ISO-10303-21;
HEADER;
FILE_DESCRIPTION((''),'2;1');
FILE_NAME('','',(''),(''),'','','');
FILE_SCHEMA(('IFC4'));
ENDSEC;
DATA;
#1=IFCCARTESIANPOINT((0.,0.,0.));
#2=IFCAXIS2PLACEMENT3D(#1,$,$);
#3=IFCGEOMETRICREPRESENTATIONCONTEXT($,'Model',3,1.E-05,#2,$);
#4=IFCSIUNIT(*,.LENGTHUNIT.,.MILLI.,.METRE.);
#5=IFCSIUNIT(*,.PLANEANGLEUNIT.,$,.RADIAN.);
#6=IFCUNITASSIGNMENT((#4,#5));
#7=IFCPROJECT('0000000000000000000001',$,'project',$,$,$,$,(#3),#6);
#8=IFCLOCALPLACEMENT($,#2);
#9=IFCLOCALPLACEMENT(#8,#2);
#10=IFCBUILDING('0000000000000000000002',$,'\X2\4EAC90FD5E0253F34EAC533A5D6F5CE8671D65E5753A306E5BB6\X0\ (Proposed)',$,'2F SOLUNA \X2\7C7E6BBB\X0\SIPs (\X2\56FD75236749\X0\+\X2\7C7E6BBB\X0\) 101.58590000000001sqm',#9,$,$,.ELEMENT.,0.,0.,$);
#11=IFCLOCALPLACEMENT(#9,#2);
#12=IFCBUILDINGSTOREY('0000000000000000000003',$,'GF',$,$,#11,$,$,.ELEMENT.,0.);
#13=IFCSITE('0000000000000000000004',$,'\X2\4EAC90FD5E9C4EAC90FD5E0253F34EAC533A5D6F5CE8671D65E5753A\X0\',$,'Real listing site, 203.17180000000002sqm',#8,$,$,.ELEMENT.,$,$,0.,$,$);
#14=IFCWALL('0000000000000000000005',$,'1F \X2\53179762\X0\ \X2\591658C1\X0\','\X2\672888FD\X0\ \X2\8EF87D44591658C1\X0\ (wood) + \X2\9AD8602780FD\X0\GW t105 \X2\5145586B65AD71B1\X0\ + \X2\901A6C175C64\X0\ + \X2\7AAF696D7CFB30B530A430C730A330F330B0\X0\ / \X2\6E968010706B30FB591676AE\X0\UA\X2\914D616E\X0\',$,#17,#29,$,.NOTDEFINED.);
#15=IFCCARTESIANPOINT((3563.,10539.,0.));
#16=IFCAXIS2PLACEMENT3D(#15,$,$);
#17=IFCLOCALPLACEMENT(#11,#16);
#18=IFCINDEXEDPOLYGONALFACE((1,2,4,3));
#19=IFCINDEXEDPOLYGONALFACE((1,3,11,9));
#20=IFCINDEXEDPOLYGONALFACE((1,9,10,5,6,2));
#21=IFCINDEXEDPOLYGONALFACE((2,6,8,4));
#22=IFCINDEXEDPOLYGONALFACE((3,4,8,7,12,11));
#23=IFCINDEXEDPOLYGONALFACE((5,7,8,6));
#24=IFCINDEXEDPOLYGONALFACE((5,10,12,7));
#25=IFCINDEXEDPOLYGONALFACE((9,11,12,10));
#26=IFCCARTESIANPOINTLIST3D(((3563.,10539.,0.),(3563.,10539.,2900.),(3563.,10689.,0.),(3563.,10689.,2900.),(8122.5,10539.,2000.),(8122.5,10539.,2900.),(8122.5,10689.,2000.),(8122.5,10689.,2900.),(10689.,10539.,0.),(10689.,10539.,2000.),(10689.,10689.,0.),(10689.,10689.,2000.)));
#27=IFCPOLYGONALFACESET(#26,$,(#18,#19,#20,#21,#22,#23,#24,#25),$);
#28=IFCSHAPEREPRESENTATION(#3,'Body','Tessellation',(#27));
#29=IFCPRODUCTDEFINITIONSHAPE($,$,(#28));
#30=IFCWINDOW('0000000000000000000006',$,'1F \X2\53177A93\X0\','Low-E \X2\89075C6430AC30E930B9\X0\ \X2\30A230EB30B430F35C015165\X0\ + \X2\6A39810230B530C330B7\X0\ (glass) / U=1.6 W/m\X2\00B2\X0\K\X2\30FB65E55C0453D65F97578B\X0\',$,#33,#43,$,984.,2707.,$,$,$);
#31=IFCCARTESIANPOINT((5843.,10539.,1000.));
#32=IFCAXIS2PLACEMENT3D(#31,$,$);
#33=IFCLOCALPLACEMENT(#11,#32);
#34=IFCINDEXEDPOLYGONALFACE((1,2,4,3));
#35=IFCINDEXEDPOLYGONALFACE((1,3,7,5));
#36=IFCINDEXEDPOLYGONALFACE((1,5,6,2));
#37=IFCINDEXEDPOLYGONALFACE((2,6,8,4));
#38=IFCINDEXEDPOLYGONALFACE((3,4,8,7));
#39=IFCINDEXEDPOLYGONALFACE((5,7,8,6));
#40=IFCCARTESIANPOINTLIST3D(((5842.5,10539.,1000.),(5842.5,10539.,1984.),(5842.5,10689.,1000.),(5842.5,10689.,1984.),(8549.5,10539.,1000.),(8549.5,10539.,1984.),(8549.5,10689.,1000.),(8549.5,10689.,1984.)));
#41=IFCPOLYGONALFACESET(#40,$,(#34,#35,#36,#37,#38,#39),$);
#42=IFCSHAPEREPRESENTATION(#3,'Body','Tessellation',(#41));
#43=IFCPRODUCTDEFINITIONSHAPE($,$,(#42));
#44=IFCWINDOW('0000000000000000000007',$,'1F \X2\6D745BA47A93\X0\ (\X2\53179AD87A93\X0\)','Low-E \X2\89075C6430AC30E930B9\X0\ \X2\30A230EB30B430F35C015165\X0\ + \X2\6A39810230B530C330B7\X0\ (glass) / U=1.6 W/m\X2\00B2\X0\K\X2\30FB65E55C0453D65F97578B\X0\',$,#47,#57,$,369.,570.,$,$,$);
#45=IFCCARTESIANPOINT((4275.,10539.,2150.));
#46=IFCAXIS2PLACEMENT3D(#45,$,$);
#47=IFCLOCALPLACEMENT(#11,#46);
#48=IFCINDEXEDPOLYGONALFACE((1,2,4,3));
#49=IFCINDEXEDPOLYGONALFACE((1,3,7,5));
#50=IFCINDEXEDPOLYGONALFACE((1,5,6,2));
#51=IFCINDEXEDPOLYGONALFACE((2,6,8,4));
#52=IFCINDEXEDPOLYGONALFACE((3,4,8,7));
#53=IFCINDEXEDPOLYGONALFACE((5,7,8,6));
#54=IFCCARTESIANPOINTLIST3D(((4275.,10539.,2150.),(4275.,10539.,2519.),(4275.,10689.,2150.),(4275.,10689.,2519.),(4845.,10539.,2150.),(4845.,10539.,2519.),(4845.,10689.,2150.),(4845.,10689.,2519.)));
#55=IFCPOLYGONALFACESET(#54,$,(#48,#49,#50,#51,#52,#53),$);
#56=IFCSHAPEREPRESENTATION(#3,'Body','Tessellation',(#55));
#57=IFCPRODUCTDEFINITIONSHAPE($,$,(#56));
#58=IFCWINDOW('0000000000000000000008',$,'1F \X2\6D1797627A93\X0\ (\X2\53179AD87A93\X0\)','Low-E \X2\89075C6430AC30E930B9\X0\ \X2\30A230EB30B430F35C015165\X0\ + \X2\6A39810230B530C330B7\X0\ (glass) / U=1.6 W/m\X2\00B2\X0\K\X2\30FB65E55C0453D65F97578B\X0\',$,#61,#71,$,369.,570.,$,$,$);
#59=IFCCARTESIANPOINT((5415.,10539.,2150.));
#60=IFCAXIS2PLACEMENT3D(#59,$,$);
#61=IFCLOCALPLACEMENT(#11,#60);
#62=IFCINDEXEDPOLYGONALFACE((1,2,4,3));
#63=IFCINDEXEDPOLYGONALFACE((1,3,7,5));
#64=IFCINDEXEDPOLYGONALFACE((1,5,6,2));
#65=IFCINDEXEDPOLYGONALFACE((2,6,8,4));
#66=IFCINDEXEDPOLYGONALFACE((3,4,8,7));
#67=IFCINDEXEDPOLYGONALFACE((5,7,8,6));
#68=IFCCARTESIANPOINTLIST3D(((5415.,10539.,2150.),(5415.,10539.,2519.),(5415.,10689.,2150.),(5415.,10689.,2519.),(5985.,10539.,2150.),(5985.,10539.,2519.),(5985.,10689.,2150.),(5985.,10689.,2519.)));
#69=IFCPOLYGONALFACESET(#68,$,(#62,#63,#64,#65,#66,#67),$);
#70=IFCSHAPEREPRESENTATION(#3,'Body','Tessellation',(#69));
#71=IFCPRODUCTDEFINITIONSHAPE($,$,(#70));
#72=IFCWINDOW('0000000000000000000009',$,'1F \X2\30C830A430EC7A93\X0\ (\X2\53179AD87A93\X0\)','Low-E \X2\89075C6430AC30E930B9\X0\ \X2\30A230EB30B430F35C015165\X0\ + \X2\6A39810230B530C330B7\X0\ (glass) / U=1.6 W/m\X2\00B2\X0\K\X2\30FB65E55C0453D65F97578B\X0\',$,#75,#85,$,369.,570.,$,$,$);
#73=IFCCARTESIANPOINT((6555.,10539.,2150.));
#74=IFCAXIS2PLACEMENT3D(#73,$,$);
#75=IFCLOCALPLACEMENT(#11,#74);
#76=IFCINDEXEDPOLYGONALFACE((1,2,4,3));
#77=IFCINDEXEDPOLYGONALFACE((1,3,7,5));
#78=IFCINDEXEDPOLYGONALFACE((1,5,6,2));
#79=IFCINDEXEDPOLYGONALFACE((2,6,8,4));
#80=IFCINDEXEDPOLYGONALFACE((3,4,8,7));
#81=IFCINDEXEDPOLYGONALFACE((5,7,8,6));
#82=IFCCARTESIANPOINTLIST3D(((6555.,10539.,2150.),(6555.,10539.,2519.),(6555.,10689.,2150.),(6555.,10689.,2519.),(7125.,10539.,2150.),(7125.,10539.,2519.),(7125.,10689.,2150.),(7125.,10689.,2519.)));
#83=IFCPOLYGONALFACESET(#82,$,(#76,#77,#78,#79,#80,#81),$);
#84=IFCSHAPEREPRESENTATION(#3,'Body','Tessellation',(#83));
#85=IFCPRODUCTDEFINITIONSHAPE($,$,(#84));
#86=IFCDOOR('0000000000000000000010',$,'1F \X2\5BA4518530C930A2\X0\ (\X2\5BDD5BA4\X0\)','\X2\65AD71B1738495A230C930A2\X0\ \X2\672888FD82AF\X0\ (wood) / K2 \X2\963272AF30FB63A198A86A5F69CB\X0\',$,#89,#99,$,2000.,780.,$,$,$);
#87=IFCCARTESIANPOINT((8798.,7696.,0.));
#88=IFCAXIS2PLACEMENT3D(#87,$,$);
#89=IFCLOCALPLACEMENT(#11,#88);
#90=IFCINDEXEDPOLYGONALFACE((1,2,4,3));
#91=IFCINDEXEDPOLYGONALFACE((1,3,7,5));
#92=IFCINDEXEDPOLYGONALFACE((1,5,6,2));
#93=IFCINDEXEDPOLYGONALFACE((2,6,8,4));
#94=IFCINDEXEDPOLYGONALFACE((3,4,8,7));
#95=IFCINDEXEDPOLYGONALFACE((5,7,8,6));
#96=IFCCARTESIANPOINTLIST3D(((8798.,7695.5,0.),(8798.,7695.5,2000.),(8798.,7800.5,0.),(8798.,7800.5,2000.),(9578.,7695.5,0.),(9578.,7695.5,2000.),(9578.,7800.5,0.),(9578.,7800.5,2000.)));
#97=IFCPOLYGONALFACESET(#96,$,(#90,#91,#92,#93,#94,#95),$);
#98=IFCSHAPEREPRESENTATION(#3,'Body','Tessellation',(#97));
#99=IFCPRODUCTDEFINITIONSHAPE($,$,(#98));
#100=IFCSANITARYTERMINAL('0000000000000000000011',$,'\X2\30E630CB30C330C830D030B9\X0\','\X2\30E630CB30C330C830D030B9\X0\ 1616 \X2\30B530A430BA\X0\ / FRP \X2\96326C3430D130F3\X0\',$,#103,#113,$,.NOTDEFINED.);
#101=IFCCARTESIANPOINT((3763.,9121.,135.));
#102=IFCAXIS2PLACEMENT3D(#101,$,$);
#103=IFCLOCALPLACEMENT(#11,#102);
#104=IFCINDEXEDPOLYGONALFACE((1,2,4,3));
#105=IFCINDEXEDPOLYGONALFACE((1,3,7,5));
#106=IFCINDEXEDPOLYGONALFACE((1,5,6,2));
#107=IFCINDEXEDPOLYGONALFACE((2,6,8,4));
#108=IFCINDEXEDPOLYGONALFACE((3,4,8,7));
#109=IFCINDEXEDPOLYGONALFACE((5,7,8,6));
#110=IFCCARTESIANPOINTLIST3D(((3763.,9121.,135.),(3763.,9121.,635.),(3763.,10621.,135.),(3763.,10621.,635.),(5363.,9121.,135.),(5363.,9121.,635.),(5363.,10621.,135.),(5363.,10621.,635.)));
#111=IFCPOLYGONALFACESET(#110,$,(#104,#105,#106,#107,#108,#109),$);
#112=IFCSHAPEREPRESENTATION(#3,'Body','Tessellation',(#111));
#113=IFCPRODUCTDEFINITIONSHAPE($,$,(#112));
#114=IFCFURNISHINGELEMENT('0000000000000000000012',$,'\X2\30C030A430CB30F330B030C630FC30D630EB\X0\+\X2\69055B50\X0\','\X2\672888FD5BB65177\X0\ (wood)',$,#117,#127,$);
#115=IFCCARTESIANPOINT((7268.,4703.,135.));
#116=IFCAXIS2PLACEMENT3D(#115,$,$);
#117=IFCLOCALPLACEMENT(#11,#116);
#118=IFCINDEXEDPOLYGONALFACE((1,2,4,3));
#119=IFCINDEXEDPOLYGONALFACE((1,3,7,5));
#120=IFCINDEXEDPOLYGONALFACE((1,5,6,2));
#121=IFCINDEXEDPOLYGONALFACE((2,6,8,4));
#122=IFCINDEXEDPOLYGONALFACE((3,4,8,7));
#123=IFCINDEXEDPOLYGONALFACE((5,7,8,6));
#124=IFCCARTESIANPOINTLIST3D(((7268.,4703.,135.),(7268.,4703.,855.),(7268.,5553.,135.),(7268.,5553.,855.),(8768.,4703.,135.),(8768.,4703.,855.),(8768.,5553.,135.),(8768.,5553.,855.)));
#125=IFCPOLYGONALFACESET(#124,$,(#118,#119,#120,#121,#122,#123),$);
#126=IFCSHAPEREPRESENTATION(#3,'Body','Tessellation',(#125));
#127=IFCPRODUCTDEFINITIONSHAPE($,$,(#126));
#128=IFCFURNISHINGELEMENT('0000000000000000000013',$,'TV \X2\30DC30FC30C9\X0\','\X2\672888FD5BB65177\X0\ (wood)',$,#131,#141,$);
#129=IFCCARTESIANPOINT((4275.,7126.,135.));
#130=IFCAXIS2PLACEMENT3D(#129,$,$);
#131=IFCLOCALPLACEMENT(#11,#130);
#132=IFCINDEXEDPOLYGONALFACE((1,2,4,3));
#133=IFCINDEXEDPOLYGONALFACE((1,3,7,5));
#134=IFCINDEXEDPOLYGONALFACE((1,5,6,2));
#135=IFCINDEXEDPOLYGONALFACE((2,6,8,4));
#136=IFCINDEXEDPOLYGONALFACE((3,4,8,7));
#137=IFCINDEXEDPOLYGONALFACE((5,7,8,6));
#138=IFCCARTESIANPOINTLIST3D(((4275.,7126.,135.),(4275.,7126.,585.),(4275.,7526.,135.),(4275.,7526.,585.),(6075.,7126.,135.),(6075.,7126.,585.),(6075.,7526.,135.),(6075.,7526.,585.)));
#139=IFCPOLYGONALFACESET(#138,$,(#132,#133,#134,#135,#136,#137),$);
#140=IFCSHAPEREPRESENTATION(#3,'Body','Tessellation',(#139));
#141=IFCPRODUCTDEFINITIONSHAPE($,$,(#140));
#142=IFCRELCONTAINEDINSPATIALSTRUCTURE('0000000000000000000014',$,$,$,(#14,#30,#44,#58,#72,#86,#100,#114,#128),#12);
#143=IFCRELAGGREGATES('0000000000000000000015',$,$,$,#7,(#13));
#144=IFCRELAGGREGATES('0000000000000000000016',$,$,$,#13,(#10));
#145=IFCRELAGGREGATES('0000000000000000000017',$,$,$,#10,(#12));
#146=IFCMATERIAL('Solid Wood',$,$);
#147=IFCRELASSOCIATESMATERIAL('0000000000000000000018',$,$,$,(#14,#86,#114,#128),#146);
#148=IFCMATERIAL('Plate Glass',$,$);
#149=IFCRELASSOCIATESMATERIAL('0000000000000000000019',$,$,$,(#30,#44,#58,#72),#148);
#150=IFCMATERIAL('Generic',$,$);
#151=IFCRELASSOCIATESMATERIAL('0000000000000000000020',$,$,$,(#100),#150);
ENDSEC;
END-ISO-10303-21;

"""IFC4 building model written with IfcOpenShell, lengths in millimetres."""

from ifc_helpers import new_model, si_unit, frame, frame_2d, origin, place, context, project, spatial, rectangle, extrude, material, element, fill, save


model = new_model("IFC4")

# Units and contexts
model_context = context("Model", 3, precision=1e-05, world=origin())
ifc_project = project(units=[si_unit("LENGTHUNIT", "METRE", prefix="MILLI"), si_unit("PLANEANGLEUNIT", "RADIAN")], contexts=[model_context])

# Site, building, storey
site_placement = place(None, origin())
site = spatial("IfcSite", under=ifc_project, at=site_placement, Name="京都府京都市右京区嵯峨朝日町", ObjectType="Real listing site, 203.17180000000002sqm", CompositionType="ELEMENT", RefElevation=0.0)
building_placement = place(site_placement, origin())
building = spatial("IfcBuilding", under=site, at=building_placement, Name="京都市右京区嵯峨朝日町の家 (Proposed)", ObjectType="2F SOLUNA 籾殻SIPs (国産杉+籾殻) 101.58590000000001sqm", CompositionType="ELEMENT", ElevationOfRefHeight=0.0, ElevationOfTerrain=0.0)
storey_placement = place(building_placement, origin())
storey = spatial("IfcBuildingStorey", under=building, at=storey_placement, Name="GF", CompositionType="ELEMENT", Elevation=0.0)

# Wall, openings, windows
ifc_material_1 = material(Name="Solid Wood")
wall_1_placement = place(storey_placement, frame((3563.0, 10539.0, 0.0)))
wall_1 = element("IfcWall", 1, at=wall_1_placement, inside=storey, material=ifc_material_1, Name="1F 北面 外壁", Description="木製 軸組外壁 (wood) + 高性能GW t105 充填断熱 + 通気層 + 窯業系サイディング / 準耐火・外皮UA配慮", PredefinedType="NOTDEFINED", context=model_context, shape_type="SweptSolid", body=[
    extrude(rectangle(XDim=7126.0, YDim=150.0, at=frame_2d((3563.0, 75.0))), frame((3563.0, 10539.0, 0.0)), (0.0, 0.0, 1.0), 2900.0),
])
opening_1_placement = place(storey_placement, frame((5843.0, 10539.0, 1000.0)))
opening_1 = element("IfcOpeningElement", 2, at=opening_1_placement, cuts=wall_1, PredefinedType="NOTDEFINED", context=model_context, shape_type="SweptSolid", body=[
    extrude(rectangle(XDim=2707.0, YDim=150.0, at=frame_2d((1353.0, 75.0))), frame((5843.0, 10539.0, 1000.0)), (0.0, 0.0, 1.0), 984.0),
])
opening_2_placement = place(storey_placement, frame((4275.0, 10539.0, 2150.0)))
opening_2 = element("IfcOpeningElement", 3, at=opening_2_placement, cuts=wall_1, PredefinedType="NOTDEFINED", context=model_context, shape_type="SweptSolid", body=[
    extrude(rectangle(XDim=570.0, YDim=150.0, at=frame_2d((285.0, 75.0))), frame((4275.0, 10539.0, 2150.0)), (0.0, 0.0, 1.0), 369.0),
])
opening_3_placement = place(storey_placement, frame((5415.0, 10539.0, 2150.0)))
opening_3 = element("IfcOpeningElement", 4, at=opening_3_placement, cuts=wall_1, PredefinedType="NOTDEFINED", context=model_context, shape_type="SweptSolid", body=[
    extrude(rectangle(XDim=570.0, YDim=150.0, at=frame_2d((285.0, 75.0))), frame((5415.0, 10539.0, 2150.0)), (0.0, 0.0, 1.0), 369.0),
])
opening_4_placement = place(storey_placement, frame((6555.0, 10539.0, 2150.0)))
opening_4 = element("IfcOpeningElement", 5, at=opening_4_placement, cuts=wall_1, PredefinedType="NOTDEFINED", context=model_context, shape_type="SweptSolid", body=[
    extrude(rectangle(XDim=570.0, YDim=150.0, at=frame_2d((285.0, 75.0))), frame((6555.0, 10539.0, 2150.0)), (0.0, 0.0, 1.0), 369.0),
])
ifc_material_2 = material(Name="Plate Glass")
window_1_placement = place(storey_placement, frame((5843.0, 10539.0, 1000.0)))
window_1 = element("IfcWindow", 6, at=window_1_placement, inside=storey, material=ifc_material_2, Name="1F 北窓", Description="Low-E 複層ガラス アルゴン封入 + 樹脂サッシ (glass) / U=1.6 W/m²K・日射取得型", OverallHeight=984.0, OverallWidth=2707.0, context=model_context, shape_type="SweptSolid", body=[
    extrude(rectangle(XDim=2707.0, YDim=150.0, at=frame_2d((1353.0, 75.0))), frame((5843.0, 10539.0, 1000.0)), (0.0, 0.0, 1.0), 984.0),
])
fill(opening_1, window_1)
window_2_placement = place(storey_placement, frame((4275.0, 10539.0, 2150.0)))
window_2 = element("IfcWindow", 7, at=window_2_placement, inside=storey, material=ifc_material_2, Name="1F 浴室窓 (北高窓)", Description="Low-E 複層ガラス アルゴン封入 + 樹脂サッシ (glass) / U=1.6 W/m²K・日射取得型", OverallHeight=369.0, OverallWidth=570.0, context=model_context, shape_type="SweptSolid", body=[
    extrude(rectangle(XDim=570.0, YDim=150.0, at=frame_2d((285.0, 75.0))), frame((4275.0, 10539.0, 2150.0)), (0.0, 0.0, 1.0), 369.0),
])
fill(opening_2, window_2)
window_3_placement = place(storey_placement, frame((5415.0, 10539.0, 2150.0)))
window_3 = element("IfcWindow", 8, at=window_3_placement, inside=storey, material=ifc_material_2, Name="1F 洗面窓 (北高窓)", Description="Low-E 複層ガラス アルゴン封入 + 樹脂サッシ (glass) / U=1.6 W/m²K・日射取得型", OverallHeight=369.0, OverallWidth=570.0, context=model_context, shape_type="SweptSolid", body=[
    extrude(rectangle(XDim=570.0, YDim=150.0, at=frame_2d((285.0, 75.0))), frame((5415.0, 10539.0, 2150.0)), (0.0, 0.0, 1.0), 369.0),
])
fill(opening_3, window_3)
window_4_placement = place(storey_placement, frame((6555.0, 10539.0, 2150.0)))
window_4 = element("IfcWindow", 9, at=window_4_placement, inside=storey, material=ifc_material_2, Name="1F トイレ窓 (北高窓)", Description="Low-E 複層ガラス アルゴン封入 + 樹脂サッシ (glass) / U=1.6 W/m²K・日射取得型", OverallHeight=369.0, OverallWidth=570.0, context=model_context, shape_type="SweptSolid", body=[
    extrude(rectangle(XDim=570.0, YDim=150.0, at=frame_2d((285.0, 75.0))), frame((6555.0, 10539.0, 2150.0)), (0.0, 0.0, 1.0), 369.0),
])
fill(opening_4, window_4)

# Door
door_1_placement = place(storey_placement, frame((8798.0, 7696.0, 0.0)))
element("IfcDoor", 10, at=door_1_placement, inside=storey, material=ifc_material_1, Name="1F 室内ドア (寝室)", Description="断熱玄関ドア 木製芯 (wood) / K2 防犯・採風機構", OverallHeight=2000.0, OverallWidth=780.0, context=model_context, shape_type="SweptSolid", body=[
    extrude(rectangle(XDim=780.0, YDim=105.0, at=frame_2d((390.0, 52.0))), frame((8798.0, 7696.0, 0.0)), (0.0, 0.0, 1.0), 2000.0),
])

# Sanitary terminal
ifc_material_3 = material(Name="Generic")
sanitary_terminal_placement = place(storey_placement, frame((3763.0, 9121.0, 135.0)))
element("IfcSanitaryTerminal", 11, at=sanitary_terminal_placement, inside=storey, material=ifc_material_3, Name="ユニットバス", Description="ユニットバス 1616 サイズ / FRP 防水パン", PredefinedType="NOTDEFINED", context=model_context, shape_type="SweptSolid", body=[
    extrude(rectangle(XDim=1600.0, YDim=1500.0, at=frame_2d((800.0, 750.0))), frame((3763.0, 9121.0, 135.0)), (0.0, 0.0, 1.0), 500.0),
])

# Furnishing elements
furnishing_1_placement = place(storey_placement, frame((7268.0, 4703.0, 135.0)))
element("IfcFurnishingElement", 12, at=furnishing_1_placement, inside=storey, material=ifc_material_1, Name="ダイニングテーブル+椅子", Description="木製家具 (wood)", context=model_context, shape_type="SweptSolid", body=[
    extrude(rectangle(XDim=1500.0, YDim=850.0, at=frame_2d((750.0, 425.0))), frame((7268.0, 4703.0, 135.0)), (0.0, 0.0, 1.0), 720.0),
])
furnishing_2_placement = place(storey_placement, frame((4275.0, 7126.0, 135.0)))
element("IfcFurnishingElement", 13, at=furnishing_2_placement, inside=storey, material=ifc_material_1, Name="TV ボード", Description="木製家具 (wood)", context=model_context, shape_type="SweptSolid", body=[
    extrude(rectangle(XDim=1800.0, YDim=400.0, at=frame_2d((900.0, 200.0))), frame((4275.0, 7126.0, 135.0)), (0.0, 0.0, 1.0), 450.0),
])

save(model, "model.ifc")
